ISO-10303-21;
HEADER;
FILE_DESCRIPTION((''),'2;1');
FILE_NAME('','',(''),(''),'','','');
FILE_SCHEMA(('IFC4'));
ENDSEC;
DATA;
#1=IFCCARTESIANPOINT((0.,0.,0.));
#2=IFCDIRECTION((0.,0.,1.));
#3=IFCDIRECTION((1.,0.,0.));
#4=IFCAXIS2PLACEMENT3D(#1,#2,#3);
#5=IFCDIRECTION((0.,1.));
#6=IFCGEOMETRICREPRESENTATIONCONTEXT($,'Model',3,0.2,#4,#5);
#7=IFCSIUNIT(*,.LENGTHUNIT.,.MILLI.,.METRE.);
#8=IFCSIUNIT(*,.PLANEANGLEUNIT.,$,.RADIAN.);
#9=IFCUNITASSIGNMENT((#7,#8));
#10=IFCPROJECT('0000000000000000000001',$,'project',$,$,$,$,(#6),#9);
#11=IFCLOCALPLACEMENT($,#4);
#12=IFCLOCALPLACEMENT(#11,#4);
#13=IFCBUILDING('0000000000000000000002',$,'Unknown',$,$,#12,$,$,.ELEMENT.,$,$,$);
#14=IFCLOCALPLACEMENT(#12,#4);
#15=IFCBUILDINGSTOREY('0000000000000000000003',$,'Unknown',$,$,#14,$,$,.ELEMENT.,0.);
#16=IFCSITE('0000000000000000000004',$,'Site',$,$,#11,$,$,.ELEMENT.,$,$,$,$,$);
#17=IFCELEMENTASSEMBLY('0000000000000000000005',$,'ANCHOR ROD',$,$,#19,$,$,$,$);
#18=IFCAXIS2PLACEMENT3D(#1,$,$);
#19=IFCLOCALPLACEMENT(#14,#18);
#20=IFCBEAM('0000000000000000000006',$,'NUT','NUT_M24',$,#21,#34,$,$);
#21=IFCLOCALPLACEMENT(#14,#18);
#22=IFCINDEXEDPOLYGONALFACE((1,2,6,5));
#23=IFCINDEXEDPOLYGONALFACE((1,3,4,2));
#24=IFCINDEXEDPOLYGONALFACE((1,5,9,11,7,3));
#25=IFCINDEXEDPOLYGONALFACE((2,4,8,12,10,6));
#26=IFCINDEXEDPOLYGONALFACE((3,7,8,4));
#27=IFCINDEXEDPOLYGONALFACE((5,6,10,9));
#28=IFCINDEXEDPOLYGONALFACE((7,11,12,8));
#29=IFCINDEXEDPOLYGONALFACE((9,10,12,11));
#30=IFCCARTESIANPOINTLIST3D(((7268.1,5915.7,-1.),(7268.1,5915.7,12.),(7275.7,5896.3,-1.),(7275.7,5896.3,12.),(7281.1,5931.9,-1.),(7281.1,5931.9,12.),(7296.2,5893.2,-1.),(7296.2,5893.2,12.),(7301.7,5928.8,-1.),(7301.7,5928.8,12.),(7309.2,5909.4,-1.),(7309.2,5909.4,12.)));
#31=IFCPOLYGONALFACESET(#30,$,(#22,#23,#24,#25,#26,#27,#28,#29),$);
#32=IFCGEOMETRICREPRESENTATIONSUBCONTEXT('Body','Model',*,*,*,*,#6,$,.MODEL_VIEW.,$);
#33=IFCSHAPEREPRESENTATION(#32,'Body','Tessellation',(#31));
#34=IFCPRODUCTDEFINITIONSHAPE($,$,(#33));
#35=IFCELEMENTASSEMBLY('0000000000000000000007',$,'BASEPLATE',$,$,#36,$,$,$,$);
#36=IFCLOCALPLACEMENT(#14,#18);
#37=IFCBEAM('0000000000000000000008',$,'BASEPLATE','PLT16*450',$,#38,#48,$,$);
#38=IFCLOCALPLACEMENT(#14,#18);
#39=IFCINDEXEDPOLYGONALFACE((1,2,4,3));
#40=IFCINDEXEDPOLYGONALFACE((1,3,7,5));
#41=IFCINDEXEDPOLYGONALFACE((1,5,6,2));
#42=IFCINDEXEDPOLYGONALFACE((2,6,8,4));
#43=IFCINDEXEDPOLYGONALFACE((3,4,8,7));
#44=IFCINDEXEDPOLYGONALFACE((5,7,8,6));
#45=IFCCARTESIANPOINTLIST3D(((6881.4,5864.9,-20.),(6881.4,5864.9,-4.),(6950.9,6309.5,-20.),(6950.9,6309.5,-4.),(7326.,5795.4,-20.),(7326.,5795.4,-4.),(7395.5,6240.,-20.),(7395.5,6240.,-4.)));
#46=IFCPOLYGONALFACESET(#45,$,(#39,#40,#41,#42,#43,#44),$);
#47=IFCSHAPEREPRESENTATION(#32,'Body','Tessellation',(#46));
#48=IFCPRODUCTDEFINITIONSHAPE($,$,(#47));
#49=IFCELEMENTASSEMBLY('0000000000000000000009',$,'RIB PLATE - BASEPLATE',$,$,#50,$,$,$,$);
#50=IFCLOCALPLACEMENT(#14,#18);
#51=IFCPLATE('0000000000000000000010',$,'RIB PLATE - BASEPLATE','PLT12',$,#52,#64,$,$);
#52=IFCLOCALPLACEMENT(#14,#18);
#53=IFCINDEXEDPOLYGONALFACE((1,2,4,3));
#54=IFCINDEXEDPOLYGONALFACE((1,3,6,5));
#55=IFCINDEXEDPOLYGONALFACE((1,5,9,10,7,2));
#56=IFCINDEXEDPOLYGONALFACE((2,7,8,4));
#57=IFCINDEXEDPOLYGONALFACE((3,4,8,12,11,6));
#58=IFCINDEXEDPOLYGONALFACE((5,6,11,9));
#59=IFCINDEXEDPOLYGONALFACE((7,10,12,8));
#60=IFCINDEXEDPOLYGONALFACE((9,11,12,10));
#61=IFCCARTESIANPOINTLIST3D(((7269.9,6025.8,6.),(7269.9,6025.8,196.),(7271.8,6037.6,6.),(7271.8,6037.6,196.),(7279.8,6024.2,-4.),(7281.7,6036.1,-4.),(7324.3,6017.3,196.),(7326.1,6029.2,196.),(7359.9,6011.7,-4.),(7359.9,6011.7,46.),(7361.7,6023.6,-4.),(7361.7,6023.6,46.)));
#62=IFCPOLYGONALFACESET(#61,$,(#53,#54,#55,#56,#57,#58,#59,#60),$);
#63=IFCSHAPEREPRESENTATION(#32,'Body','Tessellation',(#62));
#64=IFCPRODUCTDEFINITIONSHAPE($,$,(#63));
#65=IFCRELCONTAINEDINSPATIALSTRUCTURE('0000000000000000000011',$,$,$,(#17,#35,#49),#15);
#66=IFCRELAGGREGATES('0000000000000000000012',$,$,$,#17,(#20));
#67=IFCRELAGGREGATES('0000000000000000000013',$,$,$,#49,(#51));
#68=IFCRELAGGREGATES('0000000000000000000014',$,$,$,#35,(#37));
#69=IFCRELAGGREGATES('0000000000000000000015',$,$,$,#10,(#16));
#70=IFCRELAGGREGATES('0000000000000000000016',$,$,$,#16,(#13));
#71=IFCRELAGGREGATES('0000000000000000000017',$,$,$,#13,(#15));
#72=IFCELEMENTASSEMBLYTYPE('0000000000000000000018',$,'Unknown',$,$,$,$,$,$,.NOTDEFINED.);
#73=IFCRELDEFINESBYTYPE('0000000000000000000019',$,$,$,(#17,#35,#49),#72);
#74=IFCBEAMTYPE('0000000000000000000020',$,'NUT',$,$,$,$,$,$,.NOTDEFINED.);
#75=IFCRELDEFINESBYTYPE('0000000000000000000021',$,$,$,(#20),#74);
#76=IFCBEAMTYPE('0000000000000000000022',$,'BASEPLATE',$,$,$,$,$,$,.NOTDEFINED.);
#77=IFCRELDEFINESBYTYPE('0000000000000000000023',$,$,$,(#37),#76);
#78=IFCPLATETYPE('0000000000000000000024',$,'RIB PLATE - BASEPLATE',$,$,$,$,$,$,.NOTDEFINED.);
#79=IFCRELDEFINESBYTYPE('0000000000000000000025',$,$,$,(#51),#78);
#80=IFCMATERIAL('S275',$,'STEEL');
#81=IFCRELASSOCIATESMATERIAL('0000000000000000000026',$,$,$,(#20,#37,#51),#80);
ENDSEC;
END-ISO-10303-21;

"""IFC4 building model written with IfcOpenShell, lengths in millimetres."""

from ifc_helpers import new_model, si_unit, direction, frame, origin_with_axes, origin_2d_with_axis, place, context, subcontext, project, spatial, polyline, line, indexed_curve, rectangle, outline, extrude, material, material_profile, profile_set, profile_usage, type_object, element, aggregate, save


model = new_model("IFC4")

# Units and contexts
model_context = context("Model", 3, precision=0.2, world=origin_with_axes(), true_north=direction((0.0, 1.0)))
body_context = subcontext(model_context, "Body", "Model", "MODEL_VIEW")
ifc_project = project(units=[si_unit("LENGTHUNIT", "METRE", prefix="MILLI"), si_unit("PLANEANGLEUNIT", "RADIAN")], contexts=[model_context])

# Site, building, storey
site_placement = place(None, origin_with_axes())
site = spatial("IfcSite", under=ifc_project, at=site_placement, Name="Site", CompositionType="ELEMENT")
building_placement = place(site_placement, origin_with_axes())
building = spatial("IfcBuilding", under=site, at=building_placement, Name="Unknown", CompositionType="ELEMENT")
storey_placement = place(building_placement, origin_with_axes())
storey = spatial("IfcBuildingStorey", under=building, at=storey_placement, Name="Unknown", CompositionType="ELEMENT", Elevation=0.0)

# Element assembly
element_assembly_type = type_object("IfcElementAssemblyType", Name="Unknown", PredefinedType="NOTDEFINED")
ifc_material_1 = material(Name="S275", Category="STEEL")
assembly_1_placement = place(storey_placement, frame((7288.7, 5912.5, 39.0), z_axis=(0.154419, 0.988005, 0.0), x_axis=(0.0, 0.0, -1.0)))
assembly_1 = element("IfcElementAssembly", 1, at=assembly_1_placement, inside=storey, type_object=element_assembly_type, Name="ANCHOR ROD")

# Beam
ifc_material_profile_1 = material_profile(ifc_material_1, outline(polyline([(18.0, 10.4), (0.0, 20.8), (-18.0, 10.4), (-18.0, -10.4), (0.0, -20.8), (18.0, -10.4), (18.0, 10.4)])), Name="NUT_M24")
ifc_profile_set_1 = profile_set([ifc_material_profile_1])
ifc_profile_usage_1 = profile_usage(ifc_profile_set_1, cardinal=5)
beam_type_1 = type_object("IfcBeamType", Name="NUT", PredefinedType="NOTDEFINED")
beam_1_placement = place(assembly_1_placement, frame((27.0, 0.0, 0.0), z_axis=(0.0, 0.003456, 0.999994), x_axis=(1.0, 0.0, 0.0)))
beam_1 = element("IfcBeam", 2, at=beam_1_placement, type_object=beam_type_1, material=ifc_profile_usage_1, Name="NUT", Description="NUT_M24", context=body_context, shape_type="SolidModel", body=[
    extrude(outline(polyline([(18.0, 10.4), (0.0, 20.8), (-18.0, 10.4), (-18.0, -10.4), (0.0, -20.8), (18.0, -10.4), (18.0, 10.4)])), frame((0.0, 0.0, 0.0), z_axis=(-1.0, 0.0, 0.0), x_axis=(0.0, 0.0, 1.0)), (0.0, 0.0, -1.0), 13.0),
])
aggregate(assembly_1, [beam_1])

# Element assembly, beam
assembly_2_placement = place(storey_placement, frame((7360.8, 6017.7, -12.0), z_axis=(0.0, 0.0, 1.0), x_axis=(-0.988005, 0.154419, 0.0)))
assembly_2 = element("IfcElementAssembly", 3, at=assembly_2_placement, inside=storey, type_object=element_assembly_type, Name="BASEPLATE")
ifc_material_profile_2 = material_profile(ifc_material_1, rectangle(XDim=16.0, YDim=450.0, at=origin_2d_with_axis()), Name="PLT16*450")
ifc_profile_set_2 = profile_set([ifc_material_profile_2])
ifc_profile_usage_2 = profile_usage(ifc_profile_set_2, cardinal=8)
beam_type_2 = type_object("IfcBeamType", Name="BASEPLATE", PredefinedType="NOTDEFINED")
beam_2_placement = place(assembly_2_placement, origin_with_axes())
beam_2 = element("IfcBeam", 4, at=beam_2_placement, type_object=beam_type_2, material=ifc_profile_usage_2, Name="BASEPLATE", Description="PLT16*450", context=body_context, shape_type="SolidModel", body=[
    extrude(rectangle(XDim=16.0, YDim=450.0, at=origin_2d_with_axis()), frame((0.0, 0.0, 0.0), z_axis=(-1.0, 0.0, 0.0), x_axis=(0.0, 0.0, 1.0)), (0.0, 0.0, -1.0), 450.0),
])

# Element assembly, plate
assembly_3_placement = place(storey_placement, frame((7360.8, 6017.7, -4.0), z_axis=(0.154413, 0.988006, 0.0), x_axis=(-0.988006, 0.154413, 0.0)))
assembly_3 = element("IfcElementAssembly", 5, at=assembly_3_placement, inside=storey, type_object=element_assembly_type, Name="RIB PLATE - BASEPLATE")
ifc_material_profile_3 = material_profile(ifc_material_1, outline(indexed_curve([(0.0, 0.0), (81.0, 0.0), (91.0, 10.0), (91.0, 200.0), (36.0, 200.0), (0.0, 50.0)], segments=[line(1, 2, 3, 4, 5, 6, 1)])), Name="PLT12")
ifc_profile_set_3 = profile_set([ifc_material_profile_3])
ifc_profile_usage_3 = profile_usage(ifc_profile_set_3, cardinal=5)
plate_type_1 = type_object("IfcPlateType", Name="RIB PLATE - BASEPLATE", PredefinedType="NOTDEFINED")
plate_1_placement = place(assembly_3_placement, origin_with_axes())
plate_1 = element("IfcPlate", 6, at=plate_1_placement, type_object=plate_type_1, material=ifc_profile_usage_3, Name="RIB PLATE - BASEPLATE", Description="PLT12", context=body_context, shape_type="SolidModel", body=[
    extrude(outline(indexed_curve([(0.0, 0.0), (81.0, 0.0), (91.0, 10.0), (91.0, 200.0), (36.0, 200.0), (0.0, 50.0)], segments=[line(1, 2, 3, 4, 5, 6, 1)])), frame((0.0, 0.0, 6.0), z_axis=(0.0, 0.0, 1.0), x_axis=(1.0, 0.0, 0.0)), (0.0, 0.0, -1.0), 12.0),
])
aggregate(assembly_3, [plate_1])

aggregate(assembly_2, [beam_2])

save(model, "model.ifc")
